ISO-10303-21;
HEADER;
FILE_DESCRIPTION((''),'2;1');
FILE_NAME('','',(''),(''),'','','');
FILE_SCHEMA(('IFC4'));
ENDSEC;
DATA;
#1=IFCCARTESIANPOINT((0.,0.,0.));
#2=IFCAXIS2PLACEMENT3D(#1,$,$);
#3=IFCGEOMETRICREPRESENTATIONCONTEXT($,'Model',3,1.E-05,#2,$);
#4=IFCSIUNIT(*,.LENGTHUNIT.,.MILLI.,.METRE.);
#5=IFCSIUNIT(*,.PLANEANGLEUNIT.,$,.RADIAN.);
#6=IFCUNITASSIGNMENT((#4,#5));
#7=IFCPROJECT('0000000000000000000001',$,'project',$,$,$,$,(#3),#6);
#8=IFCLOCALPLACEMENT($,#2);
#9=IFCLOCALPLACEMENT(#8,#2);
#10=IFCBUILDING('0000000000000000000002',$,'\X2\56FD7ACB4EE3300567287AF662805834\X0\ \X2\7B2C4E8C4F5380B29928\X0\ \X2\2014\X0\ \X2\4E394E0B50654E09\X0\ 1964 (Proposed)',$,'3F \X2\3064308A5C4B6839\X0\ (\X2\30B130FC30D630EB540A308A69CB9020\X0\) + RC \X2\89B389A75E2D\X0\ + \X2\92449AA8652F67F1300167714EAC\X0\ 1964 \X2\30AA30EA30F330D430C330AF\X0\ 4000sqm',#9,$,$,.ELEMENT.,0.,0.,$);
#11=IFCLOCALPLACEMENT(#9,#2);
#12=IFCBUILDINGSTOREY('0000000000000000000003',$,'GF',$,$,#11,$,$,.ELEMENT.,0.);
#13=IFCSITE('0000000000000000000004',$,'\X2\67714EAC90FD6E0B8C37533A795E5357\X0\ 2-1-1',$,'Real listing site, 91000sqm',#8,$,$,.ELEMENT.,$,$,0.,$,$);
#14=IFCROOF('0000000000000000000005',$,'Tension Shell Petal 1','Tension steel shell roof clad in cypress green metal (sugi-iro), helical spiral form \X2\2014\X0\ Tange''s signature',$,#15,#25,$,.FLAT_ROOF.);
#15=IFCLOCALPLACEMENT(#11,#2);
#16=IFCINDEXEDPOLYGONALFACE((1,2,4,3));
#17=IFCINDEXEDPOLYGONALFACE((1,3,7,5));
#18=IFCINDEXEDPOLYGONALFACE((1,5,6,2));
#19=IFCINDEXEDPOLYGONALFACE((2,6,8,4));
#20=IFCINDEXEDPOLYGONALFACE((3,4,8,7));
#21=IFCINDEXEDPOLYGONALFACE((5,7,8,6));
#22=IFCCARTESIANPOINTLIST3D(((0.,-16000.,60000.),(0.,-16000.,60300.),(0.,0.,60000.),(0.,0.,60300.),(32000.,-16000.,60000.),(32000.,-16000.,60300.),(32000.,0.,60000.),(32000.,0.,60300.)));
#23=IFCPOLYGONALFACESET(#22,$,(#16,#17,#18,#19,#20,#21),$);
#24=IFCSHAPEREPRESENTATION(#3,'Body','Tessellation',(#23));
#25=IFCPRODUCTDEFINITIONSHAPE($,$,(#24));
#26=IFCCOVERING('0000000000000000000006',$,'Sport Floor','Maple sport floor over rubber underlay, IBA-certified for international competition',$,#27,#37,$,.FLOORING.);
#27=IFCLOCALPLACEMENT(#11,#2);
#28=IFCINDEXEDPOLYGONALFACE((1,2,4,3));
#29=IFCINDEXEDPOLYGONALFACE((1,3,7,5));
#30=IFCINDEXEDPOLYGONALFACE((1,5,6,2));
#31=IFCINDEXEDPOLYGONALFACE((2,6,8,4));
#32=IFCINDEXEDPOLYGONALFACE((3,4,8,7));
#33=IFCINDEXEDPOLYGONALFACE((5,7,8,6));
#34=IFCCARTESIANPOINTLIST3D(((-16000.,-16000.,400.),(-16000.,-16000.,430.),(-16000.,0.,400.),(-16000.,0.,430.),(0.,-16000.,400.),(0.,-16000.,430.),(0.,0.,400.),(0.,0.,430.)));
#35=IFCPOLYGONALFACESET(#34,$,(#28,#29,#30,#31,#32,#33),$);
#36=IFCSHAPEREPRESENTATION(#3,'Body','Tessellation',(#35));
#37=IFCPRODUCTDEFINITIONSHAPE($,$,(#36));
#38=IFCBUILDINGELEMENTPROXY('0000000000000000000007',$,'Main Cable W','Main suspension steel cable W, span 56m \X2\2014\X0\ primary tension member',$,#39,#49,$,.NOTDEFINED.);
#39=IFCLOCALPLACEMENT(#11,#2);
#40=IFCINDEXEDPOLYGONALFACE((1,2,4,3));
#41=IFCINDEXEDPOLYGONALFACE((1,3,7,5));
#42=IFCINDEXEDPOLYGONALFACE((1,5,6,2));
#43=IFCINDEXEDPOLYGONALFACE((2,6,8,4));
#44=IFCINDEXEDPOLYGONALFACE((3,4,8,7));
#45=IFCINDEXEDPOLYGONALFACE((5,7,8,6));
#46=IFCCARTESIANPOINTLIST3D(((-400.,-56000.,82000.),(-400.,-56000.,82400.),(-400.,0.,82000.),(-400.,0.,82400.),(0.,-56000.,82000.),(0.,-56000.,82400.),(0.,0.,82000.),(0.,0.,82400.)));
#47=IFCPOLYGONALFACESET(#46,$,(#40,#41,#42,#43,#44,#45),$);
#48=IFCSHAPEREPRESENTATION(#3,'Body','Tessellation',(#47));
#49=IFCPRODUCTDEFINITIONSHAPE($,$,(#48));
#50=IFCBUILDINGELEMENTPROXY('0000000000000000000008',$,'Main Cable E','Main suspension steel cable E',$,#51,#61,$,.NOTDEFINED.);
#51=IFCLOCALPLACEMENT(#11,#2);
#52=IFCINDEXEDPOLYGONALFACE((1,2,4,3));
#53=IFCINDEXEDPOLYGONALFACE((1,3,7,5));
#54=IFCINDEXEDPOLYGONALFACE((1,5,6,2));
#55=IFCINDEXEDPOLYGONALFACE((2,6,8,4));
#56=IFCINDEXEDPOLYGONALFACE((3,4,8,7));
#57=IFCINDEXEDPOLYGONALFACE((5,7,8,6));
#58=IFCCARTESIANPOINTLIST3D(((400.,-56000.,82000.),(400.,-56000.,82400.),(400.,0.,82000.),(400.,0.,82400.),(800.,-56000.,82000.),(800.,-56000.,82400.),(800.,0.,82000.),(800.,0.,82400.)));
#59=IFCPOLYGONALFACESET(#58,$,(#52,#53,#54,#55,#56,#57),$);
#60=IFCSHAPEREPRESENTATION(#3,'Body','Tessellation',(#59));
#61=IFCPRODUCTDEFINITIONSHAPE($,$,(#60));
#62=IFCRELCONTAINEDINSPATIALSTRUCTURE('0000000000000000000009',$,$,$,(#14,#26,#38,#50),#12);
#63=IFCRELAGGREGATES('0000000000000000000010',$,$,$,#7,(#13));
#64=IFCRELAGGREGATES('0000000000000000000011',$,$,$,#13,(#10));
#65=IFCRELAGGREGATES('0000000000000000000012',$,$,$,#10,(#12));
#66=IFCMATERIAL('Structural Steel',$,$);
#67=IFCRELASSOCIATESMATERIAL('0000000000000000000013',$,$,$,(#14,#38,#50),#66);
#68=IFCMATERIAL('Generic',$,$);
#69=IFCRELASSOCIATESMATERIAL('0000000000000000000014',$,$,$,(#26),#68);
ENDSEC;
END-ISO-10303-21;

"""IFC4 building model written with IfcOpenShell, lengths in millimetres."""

from ifc_helpers import new_model, si_unit, frame, frame_2d, origin, place, context, project, spatial, rectangle, extrude, material, element, save


model = new_model("IFC4")

# Units and contexts
model_context = context("Model", 3, precision=1e-05, world=origin())
ifc_project = project(units=[si_unit("LENGTHUNIT", "METRE", prefix="MILLI"), si_unit("PLANEANGLEUNIT", "RADIAN")], contexts=[model_context])

# Site, building, storey
site_placement = place(None, origin())
site = spatial("IfcSite", under=ifc_project, at=site_placement, Name="東京都渋谷区神南 2-1-1", ObjectType="Real listing site, 91000sqm", CompositionType="ELEMENT", RefElevation=0.0)
building_placement = place(site_placement, origin())
building = spatial("IfcBuilding", under=site, at=building_placement, Name="国立代々木競技場 第二体育館 — 丹下健三 1964 (Proposed)", ObjectType="3F つり屋根 (ケーブル吊り構造) + RC 観覧席 + 鉄骨支柱、東京 1964 オリンピック 4000sqm", CompositionType="ELEMENT", ElevationOfRefHeight=0.0, ElevationOfTerrain=0.0)
storey_placement = place(building_placement, origin())
storey = spatial("IfcBuildingStorey", under=building, at=storey_placement, Name="GF", CompositionType="ELEMENT", Elevation=0.0)

# Shared definitions
ifc_material_1 = material(Name="Structural Steel")

# Roof
roof_placement = place(storey_placement, frame((0.0, -8000.0, 30000.0)))
element("IfcRoof", 1, at=roof_placement, inside=storey, material=ifc_material_1, Name="Tension Shell Petal 1", Description="Tension steel shell roof clad in cypress green metal (sugi-iro), helical spiral form — Tange's signature", PredefinedType="FLAT_ROOF", context=model_context, shape_type="SweptSolid", body=[
    extrude(rectangle(XDim=32000.0, YDim=16000.0, at=frame_2d((16000.0, 8000.0))), frame((0.0, -8000.0, 30000.0)), (0.0, 0.0, 1.0), 300.0),
])

# Covering
ifc_material_2 = material(Name="Generic")
covering_placement = place(storey_placement, frame((-8000.0, -8000.0, 200.0)))
element("IfcCovering", 2, at=covering_placement, inside=storey, material=ifc_material_2, Name="Sport Floor", Description="Maple sport floor over rubber underlay, IBA-certified for international competition", PredefinedType="FLOORING", context=model_context, shape_type="SweptSolid", body=[
    extrude(rectangle(XDim=16000.0, YDim=16000.0, at=frame_2d((8000.0, 8000.0))), frame((-8000.0, -8000.0, 200.0)), (0.0, 0.0, 1.0), 30.0),
])

# Building element proxies
proxy_1_placement = place(storey_placement, frame((-200.0, -28000.0, 41000.0)))
element("IfcBuildingElementProxy", 3, at=proxy_1_placement, inside=storey, material=ifc_material_1, Name="Main Cable W", Description="Main suspension steel cable W, span 56m — primary tension member", PredefinedType="NOTDEFINED", context=model_context, shape_type="SweptSolid", body=[
    extrude(rectangle(XDim=400.0, YDim=56000.0, at=frame_2d((200.0, 28000.0))), frame((-200.0, -28000.0, 41000.0)), (0.0, 0.0, 1.0), 400.0),
])
proxy_2_placement = place(storey_placement, frame((200.0, -28000.0, 41000.0)))
element("IfcBuildingElementProxy", 4, at=proxy_2_placement, inside=storey, material=ifc_material_1, Name="Main Cable E", Description="Main suspension steel cable E", PredefinedType="NOTDEFINED", context=model_context, shape_type="SweptSolid", body=[
    extrude(rectangle(XDim=400.0, YDim=56000.0, at=frame_2d((200.0, 28000.0))), frame((200.0, -28000.0, 41000.0)), (0.0, 0.0, 1.0), 400.0),
])

save(model, "model.ifc")
